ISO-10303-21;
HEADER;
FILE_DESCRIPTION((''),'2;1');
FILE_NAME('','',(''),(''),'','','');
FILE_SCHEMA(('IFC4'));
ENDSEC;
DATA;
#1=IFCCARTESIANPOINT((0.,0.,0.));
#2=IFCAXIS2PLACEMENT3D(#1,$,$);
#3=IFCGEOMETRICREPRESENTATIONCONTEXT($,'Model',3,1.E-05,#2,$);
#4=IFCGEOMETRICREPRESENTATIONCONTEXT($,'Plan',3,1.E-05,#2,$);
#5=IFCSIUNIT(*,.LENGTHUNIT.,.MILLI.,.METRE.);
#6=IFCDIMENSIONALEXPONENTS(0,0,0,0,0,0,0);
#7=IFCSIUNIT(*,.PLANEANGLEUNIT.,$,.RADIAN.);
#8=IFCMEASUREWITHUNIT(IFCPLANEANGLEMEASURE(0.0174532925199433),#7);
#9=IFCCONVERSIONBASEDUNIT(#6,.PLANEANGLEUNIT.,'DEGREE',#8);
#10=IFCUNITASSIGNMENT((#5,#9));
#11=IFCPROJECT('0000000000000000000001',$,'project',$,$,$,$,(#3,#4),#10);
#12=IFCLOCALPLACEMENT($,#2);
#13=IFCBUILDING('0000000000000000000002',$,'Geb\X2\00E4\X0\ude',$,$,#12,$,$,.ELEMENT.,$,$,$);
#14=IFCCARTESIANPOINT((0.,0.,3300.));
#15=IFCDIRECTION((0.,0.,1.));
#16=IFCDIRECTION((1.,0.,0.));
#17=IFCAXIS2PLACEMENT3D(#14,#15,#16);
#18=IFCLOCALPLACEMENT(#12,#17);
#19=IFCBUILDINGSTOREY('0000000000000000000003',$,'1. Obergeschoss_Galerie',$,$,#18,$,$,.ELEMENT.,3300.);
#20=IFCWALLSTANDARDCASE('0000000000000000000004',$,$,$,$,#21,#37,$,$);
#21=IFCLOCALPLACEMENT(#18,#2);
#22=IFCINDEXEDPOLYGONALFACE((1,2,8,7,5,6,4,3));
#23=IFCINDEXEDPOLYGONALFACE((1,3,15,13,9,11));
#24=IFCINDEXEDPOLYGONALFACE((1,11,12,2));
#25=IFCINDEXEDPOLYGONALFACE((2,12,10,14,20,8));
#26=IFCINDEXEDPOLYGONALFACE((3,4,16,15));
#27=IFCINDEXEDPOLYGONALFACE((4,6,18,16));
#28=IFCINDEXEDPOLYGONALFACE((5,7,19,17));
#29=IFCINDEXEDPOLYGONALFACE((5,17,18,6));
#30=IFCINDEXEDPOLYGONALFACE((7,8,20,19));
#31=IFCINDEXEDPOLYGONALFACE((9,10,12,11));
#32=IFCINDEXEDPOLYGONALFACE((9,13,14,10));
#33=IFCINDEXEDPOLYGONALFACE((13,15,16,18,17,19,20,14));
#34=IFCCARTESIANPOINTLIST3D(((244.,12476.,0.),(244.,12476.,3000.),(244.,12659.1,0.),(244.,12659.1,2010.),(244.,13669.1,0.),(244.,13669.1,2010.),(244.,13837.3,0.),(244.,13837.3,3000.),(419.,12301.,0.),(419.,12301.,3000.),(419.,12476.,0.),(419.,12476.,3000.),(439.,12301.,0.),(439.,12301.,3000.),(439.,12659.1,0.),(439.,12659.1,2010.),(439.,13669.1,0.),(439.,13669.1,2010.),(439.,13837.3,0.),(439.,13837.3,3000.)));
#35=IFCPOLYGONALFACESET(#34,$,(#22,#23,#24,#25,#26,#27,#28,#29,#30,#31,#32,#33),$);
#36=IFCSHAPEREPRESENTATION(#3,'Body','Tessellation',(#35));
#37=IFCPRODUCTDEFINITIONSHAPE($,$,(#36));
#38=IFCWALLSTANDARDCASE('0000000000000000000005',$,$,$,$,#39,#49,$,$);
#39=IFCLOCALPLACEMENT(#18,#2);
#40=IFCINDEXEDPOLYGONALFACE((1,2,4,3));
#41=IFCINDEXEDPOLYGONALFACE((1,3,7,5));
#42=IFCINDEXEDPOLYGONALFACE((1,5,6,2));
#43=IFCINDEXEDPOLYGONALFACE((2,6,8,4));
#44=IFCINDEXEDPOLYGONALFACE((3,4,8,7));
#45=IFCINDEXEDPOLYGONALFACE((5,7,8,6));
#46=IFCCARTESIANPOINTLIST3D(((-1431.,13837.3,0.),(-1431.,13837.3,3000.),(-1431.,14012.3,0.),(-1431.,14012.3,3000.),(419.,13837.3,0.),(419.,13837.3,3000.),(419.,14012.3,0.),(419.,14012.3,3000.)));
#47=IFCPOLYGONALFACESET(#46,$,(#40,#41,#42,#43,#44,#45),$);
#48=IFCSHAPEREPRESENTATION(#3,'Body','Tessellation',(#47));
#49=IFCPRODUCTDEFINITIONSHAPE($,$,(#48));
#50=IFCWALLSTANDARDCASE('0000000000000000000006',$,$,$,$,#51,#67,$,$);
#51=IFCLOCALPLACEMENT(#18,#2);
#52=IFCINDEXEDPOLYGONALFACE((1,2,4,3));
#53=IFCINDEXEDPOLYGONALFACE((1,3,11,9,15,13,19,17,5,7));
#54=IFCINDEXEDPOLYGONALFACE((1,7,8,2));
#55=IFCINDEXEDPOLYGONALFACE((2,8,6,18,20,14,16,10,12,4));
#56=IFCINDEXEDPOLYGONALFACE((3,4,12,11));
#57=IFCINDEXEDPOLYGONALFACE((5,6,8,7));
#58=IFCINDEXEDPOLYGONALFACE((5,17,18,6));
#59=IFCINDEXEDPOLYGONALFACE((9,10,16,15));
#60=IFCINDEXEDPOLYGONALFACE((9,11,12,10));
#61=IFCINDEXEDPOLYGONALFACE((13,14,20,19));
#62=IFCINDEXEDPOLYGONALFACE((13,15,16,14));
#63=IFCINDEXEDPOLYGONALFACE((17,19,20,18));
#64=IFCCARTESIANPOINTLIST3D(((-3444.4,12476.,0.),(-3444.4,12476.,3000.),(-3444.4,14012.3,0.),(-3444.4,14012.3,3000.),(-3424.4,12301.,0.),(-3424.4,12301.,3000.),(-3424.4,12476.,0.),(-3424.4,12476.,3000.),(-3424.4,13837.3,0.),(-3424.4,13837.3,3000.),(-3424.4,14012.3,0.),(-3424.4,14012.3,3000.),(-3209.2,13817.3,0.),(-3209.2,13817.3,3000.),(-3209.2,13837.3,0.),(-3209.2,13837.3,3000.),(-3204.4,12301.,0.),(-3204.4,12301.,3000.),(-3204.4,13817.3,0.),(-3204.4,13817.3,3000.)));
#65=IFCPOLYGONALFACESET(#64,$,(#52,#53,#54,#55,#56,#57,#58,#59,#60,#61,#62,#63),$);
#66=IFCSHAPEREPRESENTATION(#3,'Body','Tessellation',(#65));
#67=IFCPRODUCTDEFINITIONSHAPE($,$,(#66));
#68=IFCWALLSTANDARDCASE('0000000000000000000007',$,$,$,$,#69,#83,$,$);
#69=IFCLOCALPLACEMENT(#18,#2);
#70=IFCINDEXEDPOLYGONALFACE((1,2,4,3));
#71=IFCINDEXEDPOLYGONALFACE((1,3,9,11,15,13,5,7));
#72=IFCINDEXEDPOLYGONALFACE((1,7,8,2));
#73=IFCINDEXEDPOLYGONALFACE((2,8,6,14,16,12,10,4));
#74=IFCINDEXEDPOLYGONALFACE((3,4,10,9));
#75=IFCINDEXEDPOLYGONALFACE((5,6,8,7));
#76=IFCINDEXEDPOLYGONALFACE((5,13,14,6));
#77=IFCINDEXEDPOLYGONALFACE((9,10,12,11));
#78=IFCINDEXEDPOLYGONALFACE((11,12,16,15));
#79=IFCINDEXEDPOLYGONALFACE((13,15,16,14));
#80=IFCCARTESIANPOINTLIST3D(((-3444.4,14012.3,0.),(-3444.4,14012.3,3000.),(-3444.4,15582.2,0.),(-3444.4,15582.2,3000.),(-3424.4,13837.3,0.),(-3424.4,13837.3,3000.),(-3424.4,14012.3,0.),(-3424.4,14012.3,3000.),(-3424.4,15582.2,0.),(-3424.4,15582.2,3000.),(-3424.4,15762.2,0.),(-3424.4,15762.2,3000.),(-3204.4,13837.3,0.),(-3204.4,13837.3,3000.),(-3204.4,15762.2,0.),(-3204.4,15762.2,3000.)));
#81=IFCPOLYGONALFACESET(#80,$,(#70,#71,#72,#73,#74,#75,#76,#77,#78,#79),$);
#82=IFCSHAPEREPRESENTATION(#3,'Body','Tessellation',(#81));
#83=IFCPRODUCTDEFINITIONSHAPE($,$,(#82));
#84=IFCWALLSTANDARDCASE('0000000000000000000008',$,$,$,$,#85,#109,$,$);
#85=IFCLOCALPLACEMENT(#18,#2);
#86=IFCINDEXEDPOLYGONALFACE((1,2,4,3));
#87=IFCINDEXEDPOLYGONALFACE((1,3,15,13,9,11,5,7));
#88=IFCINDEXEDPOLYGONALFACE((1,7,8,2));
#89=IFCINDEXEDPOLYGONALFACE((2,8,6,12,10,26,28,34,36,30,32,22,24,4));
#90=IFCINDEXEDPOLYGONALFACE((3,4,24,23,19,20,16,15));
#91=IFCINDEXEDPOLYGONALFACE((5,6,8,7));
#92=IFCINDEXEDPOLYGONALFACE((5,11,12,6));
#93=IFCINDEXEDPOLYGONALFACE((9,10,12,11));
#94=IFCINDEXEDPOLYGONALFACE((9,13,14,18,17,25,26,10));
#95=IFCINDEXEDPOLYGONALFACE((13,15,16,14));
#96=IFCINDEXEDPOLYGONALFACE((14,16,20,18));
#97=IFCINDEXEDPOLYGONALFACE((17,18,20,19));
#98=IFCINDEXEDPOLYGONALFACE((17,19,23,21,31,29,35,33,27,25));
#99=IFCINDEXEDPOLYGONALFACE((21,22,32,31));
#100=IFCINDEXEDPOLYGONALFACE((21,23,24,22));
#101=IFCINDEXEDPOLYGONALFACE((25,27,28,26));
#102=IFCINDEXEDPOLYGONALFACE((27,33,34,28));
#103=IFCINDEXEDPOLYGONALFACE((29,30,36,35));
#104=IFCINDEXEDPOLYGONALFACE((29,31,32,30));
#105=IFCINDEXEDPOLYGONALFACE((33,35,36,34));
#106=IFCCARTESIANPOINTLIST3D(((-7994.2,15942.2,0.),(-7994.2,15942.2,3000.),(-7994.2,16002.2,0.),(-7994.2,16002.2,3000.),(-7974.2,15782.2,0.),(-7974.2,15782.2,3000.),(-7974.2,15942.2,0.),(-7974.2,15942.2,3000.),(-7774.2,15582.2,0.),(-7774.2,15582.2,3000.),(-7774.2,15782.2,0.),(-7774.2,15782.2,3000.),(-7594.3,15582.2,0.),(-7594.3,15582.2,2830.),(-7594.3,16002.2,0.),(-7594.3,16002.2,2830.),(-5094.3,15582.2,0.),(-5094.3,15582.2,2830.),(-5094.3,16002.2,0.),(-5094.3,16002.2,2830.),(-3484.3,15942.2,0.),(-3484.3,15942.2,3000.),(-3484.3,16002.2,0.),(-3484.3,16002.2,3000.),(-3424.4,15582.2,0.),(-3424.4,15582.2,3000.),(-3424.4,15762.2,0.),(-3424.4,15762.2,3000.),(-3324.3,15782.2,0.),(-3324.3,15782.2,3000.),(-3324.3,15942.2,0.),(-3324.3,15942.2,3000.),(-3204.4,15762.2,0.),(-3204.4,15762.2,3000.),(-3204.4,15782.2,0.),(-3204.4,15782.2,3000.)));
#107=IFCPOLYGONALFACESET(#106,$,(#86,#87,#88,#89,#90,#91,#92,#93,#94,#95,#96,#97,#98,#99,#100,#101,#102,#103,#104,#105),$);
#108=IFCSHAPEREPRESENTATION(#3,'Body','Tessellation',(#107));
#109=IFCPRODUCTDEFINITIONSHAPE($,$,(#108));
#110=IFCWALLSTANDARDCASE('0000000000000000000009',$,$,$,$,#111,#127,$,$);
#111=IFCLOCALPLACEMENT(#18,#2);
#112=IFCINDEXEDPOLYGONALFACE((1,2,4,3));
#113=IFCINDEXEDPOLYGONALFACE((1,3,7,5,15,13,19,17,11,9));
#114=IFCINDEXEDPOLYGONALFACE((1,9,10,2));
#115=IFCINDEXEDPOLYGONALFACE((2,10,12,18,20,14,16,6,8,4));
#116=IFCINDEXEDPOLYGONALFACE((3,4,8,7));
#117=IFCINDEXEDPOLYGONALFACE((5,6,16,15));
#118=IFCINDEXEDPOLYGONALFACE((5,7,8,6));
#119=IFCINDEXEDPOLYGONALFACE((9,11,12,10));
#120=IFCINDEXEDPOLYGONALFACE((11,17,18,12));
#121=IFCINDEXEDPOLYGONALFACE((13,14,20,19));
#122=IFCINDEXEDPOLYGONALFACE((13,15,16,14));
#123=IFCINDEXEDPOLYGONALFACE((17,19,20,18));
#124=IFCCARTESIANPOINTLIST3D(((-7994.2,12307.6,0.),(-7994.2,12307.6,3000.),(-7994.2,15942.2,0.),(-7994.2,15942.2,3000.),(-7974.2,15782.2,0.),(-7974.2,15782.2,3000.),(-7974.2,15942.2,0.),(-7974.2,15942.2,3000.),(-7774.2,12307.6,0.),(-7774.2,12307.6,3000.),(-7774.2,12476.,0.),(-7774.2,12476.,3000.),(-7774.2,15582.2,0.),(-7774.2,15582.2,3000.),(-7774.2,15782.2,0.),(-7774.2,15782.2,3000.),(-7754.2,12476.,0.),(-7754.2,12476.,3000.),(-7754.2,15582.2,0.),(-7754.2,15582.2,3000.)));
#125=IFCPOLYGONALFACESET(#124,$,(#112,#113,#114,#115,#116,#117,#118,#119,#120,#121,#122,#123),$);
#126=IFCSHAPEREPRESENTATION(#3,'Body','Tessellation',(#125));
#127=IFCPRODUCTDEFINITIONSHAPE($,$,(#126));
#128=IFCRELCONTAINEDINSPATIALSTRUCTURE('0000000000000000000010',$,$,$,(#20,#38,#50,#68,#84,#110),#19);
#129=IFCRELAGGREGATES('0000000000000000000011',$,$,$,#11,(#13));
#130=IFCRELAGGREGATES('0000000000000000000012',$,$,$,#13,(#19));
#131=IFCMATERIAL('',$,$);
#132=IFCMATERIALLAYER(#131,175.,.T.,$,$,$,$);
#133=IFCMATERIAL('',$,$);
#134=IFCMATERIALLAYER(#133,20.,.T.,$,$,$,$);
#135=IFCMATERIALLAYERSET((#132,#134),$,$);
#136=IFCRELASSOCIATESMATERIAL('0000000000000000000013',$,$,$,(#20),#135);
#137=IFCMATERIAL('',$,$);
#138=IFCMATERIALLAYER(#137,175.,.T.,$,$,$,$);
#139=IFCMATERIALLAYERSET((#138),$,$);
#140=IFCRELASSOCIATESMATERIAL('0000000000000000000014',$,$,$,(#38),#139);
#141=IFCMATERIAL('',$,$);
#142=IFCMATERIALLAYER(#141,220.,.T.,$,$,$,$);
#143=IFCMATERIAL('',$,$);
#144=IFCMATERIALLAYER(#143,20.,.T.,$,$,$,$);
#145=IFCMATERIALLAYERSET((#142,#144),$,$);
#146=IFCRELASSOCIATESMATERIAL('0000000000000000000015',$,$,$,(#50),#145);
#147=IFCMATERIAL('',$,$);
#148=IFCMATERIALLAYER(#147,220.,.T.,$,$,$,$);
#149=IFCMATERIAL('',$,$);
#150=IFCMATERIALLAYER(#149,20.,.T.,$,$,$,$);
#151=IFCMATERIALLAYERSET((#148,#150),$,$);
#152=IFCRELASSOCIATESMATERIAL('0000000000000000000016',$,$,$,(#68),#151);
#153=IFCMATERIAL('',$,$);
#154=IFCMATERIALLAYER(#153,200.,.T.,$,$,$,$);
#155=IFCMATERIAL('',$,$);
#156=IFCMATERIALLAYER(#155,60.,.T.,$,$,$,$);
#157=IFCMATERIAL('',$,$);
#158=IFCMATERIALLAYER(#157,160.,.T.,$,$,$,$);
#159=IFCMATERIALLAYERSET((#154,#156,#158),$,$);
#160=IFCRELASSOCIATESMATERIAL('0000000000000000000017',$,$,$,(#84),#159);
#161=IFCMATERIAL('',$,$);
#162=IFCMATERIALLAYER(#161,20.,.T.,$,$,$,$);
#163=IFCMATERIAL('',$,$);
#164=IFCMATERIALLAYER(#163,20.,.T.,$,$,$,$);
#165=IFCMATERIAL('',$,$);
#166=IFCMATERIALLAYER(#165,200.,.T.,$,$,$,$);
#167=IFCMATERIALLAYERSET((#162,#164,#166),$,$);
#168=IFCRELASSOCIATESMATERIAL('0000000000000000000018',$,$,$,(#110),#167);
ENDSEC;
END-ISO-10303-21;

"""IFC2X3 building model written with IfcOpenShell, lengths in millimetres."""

from ifc_helpers import new_model, entity, si_unit, converted_unit, frame, frame_2d, origin, origin_with_axes, place, context, project, spatial, polyline, rectangle, outline, extrude, material, layer, layer_set, layer_usage, element, save


model = new_model("IFC2X3")

# Units and contexts
model_context = context("Model", 3, precision=1e-05, world=origin())
plan_context = context("Plan", 3, precision=1e-05, world=origin())
ifc_project = project(units=[si_unit("LENGTHUNIT", "METRE", prefix="MILLI"), converted_unit("PLANEANGLEUNIT", "DEGREE", entity("IfcPlaneAngleMeasure", 0.0174532925199433), si_unit("PLANEANGLEUNIT", "RADIAN"), dimensions=[0, 0, 0, 0, 0, 0, 0])], contexts=[model_context, plan_context])

# Building, storey
building_placement = place(None, origin())
building = spatial("IfcBuilding", under=ifc_project, at=building_placement, Name="Gebäude", CompositionType="ELEMENT")
storey_placement = place(building_placement, frame((0.0, 0.0, 3300.0), z_axis=(0.0, 0.0, 1.0), x_axis=(1.0, 0.0, 0.0)))
storey = spatial("IfcBuildingStorey", under=building, at=storey_placement, Name="1. Obergeschoss_Galerie", CompositionType="ELEMENT", Elevation=3300.0)

# Wall, opening
ifc_material_1 = material(Name="")
ifc_layer_1 = layer(ifc_material_1, 175.0, ventilated=True)
ifc_material_2 = material(Name="")
ifc_layer_2 = layer(ifc_material_2, 20.0, ventilated=True)
ifc_layer_set_1 = layer_set([ifc_layer_1, ifc_layer_2])
ifc_layer_usage_1 = layer_usage(ifc_layer_set_1, "AXIS2", "POSITIVE", 0.0)
wall_1_placement = place(storey_placement, frame((439.0, 12301.0, 0.0), z_axis=(0.0, 0.0, 1.0), x_axis=(0.0, 1.0, 0.0)))
wall_1 = element("IfcWallStandardCase", 1, at=wall_1_placement, inside=storey, material=ifc_layer_usage_1, context=model_context, shape_type="SweptSolid", body=[
    extrude(outline(polyline([(175.0, 195.0), (175.0, 20.0), (0.0, 20.0), (0.0, 0.0), (1536.4, 0.0), (1536.4, 195.0), (175.0, 195.0)])), origin_with_axes(), (0.0, 0.0, 1.0), 3000.0),
])
opening_1_placement = place(wall_1_placement, frame((358.1, 0.0, 0.0), z_axis=(0.0, 1.0, 0.0), x_axis=(0.0, 0.0, 1.0)))
element("IfcOpeningElement", 2, at=opening_1_placement, cuts=wall_1, ObjectType="Opening", context=model_context, shape_type="SweptSolid", body=[
    extrude(rectangle(XDim=2010.0, YDim=1010.0, at=frame_2d((1005.0, 505.0), x_axis=(1.0, 0.0))), origin_with_axes(), (0.0, 0.0, 1.0), 195.0),
])

# Walls
ifc_material_3 = material(Name="")
ifc_layer_3 = layer(ifc_material_3, 175.0, ventilated=True)
ifc_layer_set_2 = layer_set([ifc_layer_3])
ifc_layer_usage_2 = layer_usage(ifc_layer_set_2, "AXIS2", "POSITIVE", 0.0)
wall_2_placement = place(storey_placement, frame((419.0, 14012.3, 0.0), z_axis=(0.0, 0.0, 1.0), x_axis=(-1.0, 0.0, 0.0)))
element("IfcWallStandardCase", 3, at=wall_2_placement, inside=storey, material=ifc_layer_usage_2, context=model_context, shape_type="SweptSolid", body=[
    extrude(rectangle(XDim=1850.0, YDim=175.0, at=frame_2d((925.0, 87.5), x_axis=(1.0, 0.0))), origin_with_axes(), (0.0, 0.0, 1.0), 3000.0),
])
ifc_material_4 = material(Name="")
ifc_layer_4 = layer(ifc_material_4, 220.0, ventilated=True)
ifc_material_5 = material(Name="")
ifc_layer_5 = layer(ifc_material_5, 20.0, ventilated=True)
ifc_layer_set_3 = layer_set([ifc_layer_4, ifc_layer_5])
ifc_layer_usage_3 = layer_usage(ifc_layer_set_3, "AXIS2", "POSITIVE", 0.0)
wall_3_placement = place(storey_placement, frame((-3444.4, 14012.3, 0.0), z_axis=(0.0, 0.0, 1.0), x_axis=(0.0, -1.0, 0.0)))
element("IfcWallStandardCase", 4, at=wall_3_placement, inside=storey, material=ifc_layer_usage_3, context=model_context, shape_type="SweptSolid", body=[
    extrude(outline(polyline([(0.0, 0.0), (1536.4, 0.0), (1536.4, 20.0), (1711.4, 20.0), (1711.4, 240.0), (195.0, 240.0), (195.0, 235.2), (175.0, 235.2), (175.0, 20.0), (0.0, 20.0), (0.0, 0.0)])), origin_with_axes(), (0.0, 0.0, 1.0), 3000.0),
])
ifc_material_6 = material(Name="")
ifc_layer_6 = layer(ifc_material_6, 220.0, ventilated=True)
ifc_material_7 = material(Name="")
ifc_layer_7 = layer(ifc_material_7, 20.0, ventilated=True)
ifc_layer_set_4 = layer_set([ifc_layer_6, ifc_layer_7])
ifc_layer_usage_4 = layer_usage(ifc_layer_set_4, "AXIS2", "POSITIVE", 0.0)
wall_4_placement = place(storey_placement, frame((-3444.4, 15582.2, 0.0), z_axis=(0.0, 0.0, 1.0), x_axis=(0.0, -1.0, 0.0)))
element("IfcWallStandardCase", 5, at=wall_4_placement, inside=storey, material=ifc_layer_usage_4, context=model_context, shape_type="SweptSolid", body=[
    extrude(outline(polyline([(0.0, 0.0), (1569.9, 0.0), (1569.9, 20.0), (1744.9, 20.0), (1744.9, 240.0), (-180.0, 240.0), (-180.0, 20.0), (0.0, 20.0), (0.0, 0.0)])), origin_with_axes(), (0.0, 0.0, 1.0), 3000.0),
])

# Wall, opening
ifc_material_8 = material(Name="")
ifc_layer_8 = layer(ifc_material_8, 200.0, ventilated=True)
ifc_material_9 = material(Name="")
ifc_layer_9 = layer(ifc_material_9, 60.0, ventilated=True)
ifc_material_10 = material(Name="")
ifc_layer_10 = layer(ifc_material_10, 160.0, ventilated=True)
ifc_layer_set_5 = layer_set([ifc_layer_8, ifc_layer_9, ifc_layer_10])
ifc_layer_usage_5 = layer_usage(ifc_layer_set_5, "AXIS2", "POSITIVE", 0.0)
wall_5_placement = place(storey_placement, frame((-3484.3, 16002.2, 0.0), z_axis=(0.0, 0.0, 1.0), x_axis=(-1.0, 0.0, 0.0)))
wall_5 = element("IfcWallStandardCase", 6, at=wall_5_placement, inside=storey, material=ifc_layer_usage_5, context=model_context, shape_type="SweptSolid", body=[
    extrude(outline(polyline([(0.0, 0.0), (4510.0, 0.0), (4510.0, 60.0), (4490.0, 60.0), (4490.0, 220.0), (4290.0, 220.0), (4290.0, 420.0), (-59.8, 420.0), (-59.8, 240.0), (-279.8, 240.0), (-279.8, 220.0), (-160.0, 220.0), (-160.0, 60.0), (0.0, 60.0), (0.0, 0.0)])), origin_with_axes(), (0.0, 0.0, 1.0), 3000.0),
])
opening_2_placement = place(wall_5_placement, frame((1610.0, 0.0, 0.0), z_axis=(0.0, 1.0, 0.0), x_axis=(0.0, 0.0, 1.0)))
element("IfcOpeningElement", 7, at=opening_2_placement, cuts=wall_5, ObjectType="Opening", context=model_context, shape_type="SweptSolid", body=[
    extrude(rectangle(XDim=2830.0, YDim=2500.0, at=frame_2d((1415.0, 1250.0), x_axis=(1.0, 0.0))), origin_with_axes(), (0.0, 0.0, 1.0), 420.0),
])

# Wall
ifc_material_11 = material(Name="")
ifc_layer_11 = layer(ifc_material_11, 20.0, ventilated=True)
ifc_material_12 = material(Name="")
ifc_layer_12 = layer(ifc_material_12, 20.0, ventilated=True)
ifc_material_13 = material(Name="")
ifc_layer_13 = layer(ifc_material_13, 200.0, ventilated=True)
ifc_layer_set_6 = layer_set([ifc_layer_11, ifc_layer_12, ifc_layer_13])
ifc_layer_usage_6 = layer_usage(ifc_layer_set_6, "AXIS2", "POSITIVE", 0.0)
wall_6_placement = place(storey_placement, frame((-7994.2, 15942.2, 0.0), z_axis=(0.0, 0.0, 1.0), x_axis=(0.0, -1.0, 0.0)))
element("IfcWallStandardCase", 8, at=wall_6_placement, inside=storey, material=ifc_layer_usage_6, context=model_context, shape_type="SweptSolid", body=[
    extrude(outline(polyline([(160.0, 220.0), (160.0, 20.0), (0.0, 20.0), (0.0, 0.0), (3634.6, 0.0), (3634.6, 220.0), (3466.2, 220.0), (3466.2, 240.0), (360.0, 240.0), (360.0, 220.0), (160.0, 220.0)])), origin_with_axes(), (0.0, 0.0, 1.0), 3000.0),
])

save(model, "model.ifc")
